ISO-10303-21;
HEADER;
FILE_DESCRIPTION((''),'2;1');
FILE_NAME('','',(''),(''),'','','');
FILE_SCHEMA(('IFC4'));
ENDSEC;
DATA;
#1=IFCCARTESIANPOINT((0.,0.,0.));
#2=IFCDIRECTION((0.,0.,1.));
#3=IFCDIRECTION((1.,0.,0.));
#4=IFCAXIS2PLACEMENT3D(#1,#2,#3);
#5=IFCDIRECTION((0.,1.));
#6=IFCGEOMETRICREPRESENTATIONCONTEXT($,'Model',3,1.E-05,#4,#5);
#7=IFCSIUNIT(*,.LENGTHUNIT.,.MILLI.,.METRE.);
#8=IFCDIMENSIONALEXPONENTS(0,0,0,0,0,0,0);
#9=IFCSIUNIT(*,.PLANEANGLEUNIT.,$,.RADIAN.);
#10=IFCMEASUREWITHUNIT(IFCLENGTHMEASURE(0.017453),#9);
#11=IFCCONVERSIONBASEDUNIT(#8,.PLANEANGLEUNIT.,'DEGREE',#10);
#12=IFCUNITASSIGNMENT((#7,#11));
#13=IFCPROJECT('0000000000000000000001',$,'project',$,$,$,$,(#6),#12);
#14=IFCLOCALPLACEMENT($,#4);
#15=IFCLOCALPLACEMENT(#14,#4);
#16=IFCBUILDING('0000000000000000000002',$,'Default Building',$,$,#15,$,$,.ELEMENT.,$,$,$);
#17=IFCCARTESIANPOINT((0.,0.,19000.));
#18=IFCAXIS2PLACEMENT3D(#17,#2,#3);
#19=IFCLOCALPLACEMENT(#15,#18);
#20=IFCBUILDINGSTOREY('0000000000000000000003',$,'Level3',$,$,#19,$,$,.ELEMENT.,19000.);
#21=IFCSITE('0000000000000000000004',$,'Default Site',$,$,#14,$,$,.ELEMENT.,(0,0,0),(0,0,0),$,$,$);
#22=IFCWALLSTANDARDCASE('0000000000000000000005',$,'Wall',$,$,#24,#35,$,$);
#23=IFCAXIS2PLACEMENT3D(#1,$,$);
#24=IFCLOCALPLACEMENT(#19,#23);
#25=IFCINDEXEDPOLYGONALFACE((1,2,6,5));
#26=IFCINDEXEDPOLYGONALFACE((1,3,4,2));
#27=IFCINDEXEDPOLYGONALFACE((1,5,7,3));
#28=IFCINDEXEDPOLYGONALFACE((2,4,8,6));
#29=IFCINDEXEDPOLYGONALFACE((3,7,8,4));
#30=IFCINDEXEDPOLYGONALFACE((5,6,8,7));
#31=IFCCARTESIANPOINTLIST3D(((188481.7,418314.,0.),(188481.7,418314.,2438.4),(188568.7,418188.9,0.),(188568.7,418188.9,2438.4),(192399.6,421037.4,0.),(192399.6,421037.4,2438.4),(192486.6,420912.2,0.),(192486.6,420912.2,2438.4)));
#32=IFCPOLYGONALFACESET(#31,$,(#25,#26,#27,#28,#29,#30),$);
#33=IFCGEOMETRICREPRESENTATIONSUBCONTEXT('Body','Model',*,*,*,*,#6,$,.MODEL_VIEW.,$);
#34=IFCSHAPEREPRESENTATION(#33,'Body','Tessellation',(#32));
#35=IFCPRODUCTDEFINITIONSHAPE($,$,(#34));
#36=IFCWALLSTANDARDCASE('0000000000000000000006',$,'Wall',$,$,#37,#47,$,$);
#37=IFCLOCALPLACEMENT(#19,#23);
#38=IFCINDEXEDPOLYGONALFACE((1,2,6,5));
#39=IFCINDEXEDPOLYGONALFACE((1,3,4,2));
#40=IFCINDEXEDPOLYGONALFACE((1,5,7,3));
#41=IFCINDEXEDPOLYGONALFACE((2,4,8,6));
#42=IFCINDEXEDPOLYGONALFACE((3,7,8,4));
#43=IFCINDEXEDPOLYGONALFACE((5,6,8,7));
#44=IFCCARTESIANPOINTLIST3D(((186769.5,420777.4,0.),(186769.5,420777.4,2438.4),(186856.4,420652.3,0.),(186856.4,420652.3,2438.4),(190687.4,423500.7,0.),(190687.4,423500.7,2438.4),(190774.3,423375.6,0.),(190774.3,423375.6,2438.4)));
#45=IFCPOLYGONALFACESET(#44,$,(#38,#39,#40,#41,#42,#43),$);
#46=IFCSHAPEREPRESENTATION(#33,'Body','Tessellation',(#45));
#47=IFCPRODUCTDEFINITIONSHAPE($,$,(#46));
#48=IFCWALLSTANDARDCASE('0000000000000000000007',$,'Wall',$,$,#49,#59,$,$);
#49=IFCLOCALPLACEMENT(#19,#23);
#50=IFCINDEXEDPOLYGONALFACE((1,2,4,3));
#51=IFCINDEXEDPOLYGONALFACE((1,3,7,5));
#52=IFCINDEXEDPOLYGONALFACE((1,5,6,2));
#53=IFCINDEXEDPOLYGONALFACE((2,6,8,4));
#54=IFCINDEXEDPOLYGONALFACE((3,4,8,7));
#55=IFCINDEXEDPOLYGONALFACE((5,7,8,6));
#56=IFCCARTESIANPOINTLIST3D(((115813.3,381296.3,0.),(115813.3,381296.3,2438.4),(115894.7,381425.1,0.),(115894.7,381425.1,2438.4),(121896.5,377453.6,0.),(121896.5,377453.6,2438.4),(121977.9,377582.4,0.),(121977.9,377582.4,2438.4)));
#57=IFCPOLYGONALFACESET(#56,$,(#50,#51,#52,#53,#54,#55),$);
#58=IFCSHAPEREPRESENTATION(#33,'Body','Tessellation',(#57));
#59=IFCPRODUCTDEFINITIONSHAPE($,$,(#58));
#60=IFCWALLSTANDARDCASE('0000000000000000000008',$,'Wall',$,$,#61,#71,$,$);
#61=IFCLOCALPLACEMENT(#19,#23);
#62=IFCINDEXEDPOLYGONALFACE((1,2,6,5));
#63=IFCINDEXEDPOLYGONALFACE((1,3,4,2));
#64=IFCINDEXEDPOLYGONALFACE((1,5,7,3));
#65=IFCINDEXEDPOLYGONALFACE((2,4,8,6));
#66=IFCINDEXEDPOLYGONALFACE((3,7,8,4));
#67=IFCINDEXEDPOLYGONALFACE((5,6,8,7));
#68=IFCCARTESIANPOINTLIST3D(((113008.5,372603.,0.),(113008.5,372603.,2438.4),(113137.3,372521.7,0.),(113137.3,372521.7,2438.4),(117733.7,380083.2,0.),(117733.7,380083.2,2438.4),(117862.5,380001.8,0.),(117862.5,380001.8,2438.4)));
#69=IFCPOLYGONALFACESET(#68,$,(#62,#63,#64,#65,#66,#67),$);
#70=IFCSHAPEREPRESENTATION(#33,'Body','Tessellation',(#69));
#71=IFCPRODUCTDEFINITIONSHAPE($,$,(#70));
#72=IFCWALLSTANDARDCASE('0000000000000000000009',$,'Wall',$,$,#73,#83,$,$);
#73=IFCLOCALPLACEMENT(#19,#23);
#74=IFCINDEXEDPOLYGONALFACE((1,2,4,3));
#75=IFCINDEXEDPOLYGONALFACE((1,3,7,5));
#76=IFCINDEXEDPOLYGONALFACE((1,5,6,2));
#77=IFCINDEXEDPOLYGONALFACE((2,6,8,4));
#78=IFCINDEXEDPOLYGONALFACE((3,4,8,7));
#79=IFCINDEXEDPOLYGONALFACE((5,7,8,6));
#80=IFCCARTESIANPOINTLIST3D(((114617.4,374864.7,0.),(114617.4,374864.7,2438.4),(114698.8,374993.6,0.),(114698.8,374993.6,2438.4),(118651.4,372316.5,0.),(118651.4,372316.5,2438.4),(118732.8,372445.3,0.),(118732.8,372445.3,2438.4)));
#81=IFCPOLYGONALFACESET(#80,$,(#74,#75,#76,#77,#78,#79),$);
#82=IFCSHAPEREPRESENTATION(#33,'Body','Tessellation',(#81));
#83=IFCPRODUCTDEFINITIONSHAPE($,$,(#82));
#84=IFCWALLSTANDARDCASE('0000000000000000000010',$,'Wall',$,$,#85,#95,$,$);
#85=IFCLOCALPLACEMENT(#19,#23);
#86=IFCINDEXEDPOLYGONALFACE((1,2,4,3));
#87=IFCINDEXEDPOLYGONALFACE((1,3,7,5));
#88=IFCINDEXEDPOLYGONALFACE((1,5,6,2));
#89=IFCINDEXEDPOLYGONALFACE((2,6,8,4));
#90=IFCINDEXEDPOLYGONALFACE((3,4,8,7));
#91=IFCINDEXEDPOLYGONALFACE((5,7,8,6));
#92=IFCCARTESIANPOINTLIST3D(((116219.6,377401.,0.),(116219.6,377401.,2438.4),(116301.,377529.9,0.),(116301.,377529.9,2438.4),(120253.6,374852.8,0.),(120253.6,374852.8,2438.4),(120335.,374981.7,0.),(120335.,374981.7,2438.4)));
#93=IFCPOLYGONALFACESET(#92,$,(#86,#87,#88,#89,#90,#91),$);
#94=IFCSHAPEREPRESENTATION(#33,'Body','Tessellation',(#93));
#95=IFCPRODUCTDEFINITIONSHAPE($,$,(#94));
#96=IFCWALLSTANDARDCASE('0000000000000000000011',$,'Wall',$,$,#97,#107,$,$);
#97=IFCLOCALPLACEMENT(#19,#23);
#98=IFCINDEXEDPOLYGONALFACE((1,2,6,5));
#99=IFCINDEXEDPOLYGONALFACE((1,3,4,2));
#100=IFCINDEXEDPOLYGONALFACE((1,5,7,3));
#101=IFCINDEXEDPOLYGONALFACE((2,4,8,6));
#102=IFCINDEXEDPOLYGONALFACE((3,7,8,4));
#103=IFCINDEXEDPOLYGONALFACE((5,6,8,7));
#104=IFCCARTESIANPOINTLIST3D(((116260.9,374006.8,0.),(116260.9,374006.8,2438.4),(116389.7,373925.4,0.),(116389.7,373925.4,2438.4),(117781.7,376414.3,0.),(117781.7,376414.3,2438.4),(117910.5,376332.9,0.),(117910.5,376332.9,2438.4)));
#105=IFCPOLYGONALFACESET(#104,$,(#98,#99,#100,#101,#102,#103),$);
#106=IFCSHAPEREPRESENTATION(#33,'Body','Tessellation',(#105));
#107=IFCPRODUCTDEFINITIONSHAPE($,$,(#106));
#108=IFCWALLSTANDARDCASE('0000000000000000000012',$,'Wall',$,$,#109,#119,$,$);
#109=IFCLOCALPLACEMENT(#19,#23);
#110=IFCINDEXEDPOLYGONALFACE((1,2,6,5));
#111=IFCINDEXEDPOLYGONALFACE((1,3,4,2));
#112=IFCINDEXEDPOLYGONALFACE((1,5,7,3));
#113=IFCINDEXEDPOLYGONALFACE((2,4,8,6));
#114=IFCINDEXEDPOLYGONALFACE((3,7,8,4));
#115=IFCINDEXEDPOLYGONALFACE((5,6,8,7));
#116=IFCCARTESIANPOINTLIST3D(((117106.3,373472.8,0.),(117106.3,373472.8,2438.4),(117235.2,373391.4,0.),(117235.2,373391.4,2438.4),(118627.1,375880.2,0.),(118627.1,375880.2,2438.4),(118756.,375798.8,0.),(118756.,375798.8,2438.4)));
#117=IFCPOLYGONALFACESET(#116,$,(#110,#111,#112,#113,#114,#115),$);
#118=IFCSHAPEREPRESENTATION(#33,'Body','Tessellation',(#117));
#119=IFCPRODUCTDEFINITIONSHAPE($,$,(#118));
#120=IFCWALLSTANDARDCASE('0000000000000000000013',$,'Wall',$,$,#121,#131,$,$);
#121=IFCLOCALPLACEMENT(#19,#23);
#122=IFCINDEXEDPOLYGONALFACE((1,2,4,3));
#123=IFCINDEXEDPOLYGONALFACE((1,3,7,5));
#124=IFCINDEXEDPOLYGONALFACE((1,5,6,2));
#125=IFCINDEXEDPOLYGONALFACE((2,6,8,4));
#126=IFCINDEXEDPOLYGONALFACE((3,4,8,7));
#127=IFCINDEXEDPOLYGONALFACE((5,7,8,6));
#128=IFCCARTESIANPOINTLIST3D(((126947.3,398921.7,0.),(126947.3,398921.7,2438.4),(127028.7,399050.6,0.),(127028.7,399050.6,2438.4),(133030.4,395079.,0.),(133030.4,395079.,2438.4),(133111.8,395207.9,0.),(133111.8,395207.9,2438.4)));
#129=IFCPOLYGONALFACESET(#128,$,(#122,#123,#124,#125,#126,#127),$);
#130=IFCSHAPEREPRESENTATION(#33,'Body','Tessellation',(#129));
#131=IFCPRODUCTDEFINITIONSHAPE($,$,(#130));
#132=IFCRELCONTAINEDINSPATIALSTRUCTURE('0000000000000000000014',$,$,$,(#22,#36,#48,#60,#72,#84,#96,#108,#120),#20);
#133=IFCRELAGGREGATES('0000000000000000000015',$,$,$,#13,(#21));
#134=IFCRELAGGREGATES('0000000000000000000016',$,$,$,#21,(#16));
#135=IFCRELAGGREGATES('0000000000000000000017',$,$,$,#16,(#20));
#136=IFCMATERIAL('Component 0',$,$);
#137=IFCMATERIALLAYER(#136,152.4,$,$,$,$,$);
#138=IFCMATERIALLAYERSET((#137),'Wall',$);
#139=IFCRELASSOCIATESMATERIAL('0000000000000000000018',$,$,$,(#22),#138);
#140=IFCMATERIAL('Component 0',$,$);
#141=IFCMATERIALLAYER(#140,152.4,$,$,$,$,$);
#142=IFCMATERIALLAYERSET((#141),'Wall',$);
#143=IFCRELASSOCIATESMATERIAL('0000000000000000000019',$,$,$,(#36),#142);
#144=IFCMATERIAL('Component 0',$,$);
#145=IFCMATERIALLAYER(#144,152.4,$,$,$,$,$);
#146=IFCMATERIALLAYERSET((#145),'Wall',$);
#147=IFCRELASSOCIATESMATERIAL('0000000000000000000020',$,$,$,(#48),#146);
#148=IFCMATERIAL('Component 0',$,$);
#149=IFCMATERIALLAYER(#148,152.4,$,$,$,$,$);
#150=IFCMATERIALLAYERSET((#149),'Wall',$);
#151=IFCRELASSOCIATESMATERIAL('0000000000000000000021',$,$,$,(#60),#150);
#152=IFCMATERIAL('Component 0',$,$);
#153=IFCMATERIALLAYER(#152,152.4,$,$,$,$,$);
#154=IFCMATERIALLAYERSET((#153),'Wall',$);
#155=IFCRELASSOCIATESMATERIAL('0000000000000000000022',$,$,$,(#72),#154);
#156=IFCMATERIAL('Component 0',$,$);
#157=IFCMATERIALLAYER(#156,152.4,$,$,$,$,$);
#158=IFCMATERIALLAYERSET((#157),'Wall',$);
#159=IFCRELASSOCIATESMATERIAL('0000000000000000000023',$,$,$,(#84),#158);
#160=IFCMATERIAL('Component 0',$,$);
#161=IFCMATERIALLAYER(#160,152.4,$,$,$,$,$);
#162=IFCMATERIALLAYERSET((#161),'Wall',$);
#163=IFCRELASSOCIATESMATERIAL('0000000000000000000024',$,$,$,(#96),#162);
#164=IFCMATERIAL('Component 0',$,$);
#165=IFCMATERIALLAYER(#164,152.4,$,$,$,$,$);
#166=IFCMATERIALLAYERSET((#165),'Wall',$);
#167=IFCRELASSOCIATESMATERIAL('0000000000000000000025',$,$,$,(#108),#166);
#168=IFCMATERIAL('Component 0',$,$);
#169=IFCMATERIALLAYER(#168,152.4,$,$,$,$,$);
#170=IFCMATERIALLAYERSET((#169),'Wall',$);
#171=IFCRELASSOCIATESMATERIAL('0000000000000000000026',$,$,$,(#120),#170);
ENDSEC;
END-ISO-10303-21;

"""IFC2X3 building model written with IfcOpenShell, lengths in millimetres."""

from ifc_helpers import new_model, entity, si_unit, converted_unit, direction, frame, origin_with_axes, place, context, subcontext, project, spatial, polyline, outline, extrude, material, layer, layer_set, layer_usage, element, save


model = new_model("IFC2X3")

# Units and contexts
model_context = context("Model", 3, precision=1e-05, world=origin_with_axes(), true_north=direction((0.0, 1.0)))
body_context = subcontext(model_context, "Body", "Model", "MODEL_VIEW")
ifc_project = project(units=[si_unit("LENGTHUNIT", "METRE", prefix="MILLI"), converted_unit("PLANEANGLEUNIT", "DEGREE", entity("IfcLengthMeasure", 0.017453), si_unit("PLANEANGLEUNIT", "RADIAN"), dimensions=[0, 0, 0, 0, 0, 0, 0])], contexts=[model_context])

# Site, building, storey
site_placement = place(None, origin_with_axes())
site = spatial("IfcSite", under=ifc_project, at=site_placement, Name="Default Site", CompositionType="ELEMENT", RefLatitude=(0, 0, 0), RefLongitude=(0, 0, 0))
building_placement = place(site_placement, origin_with_axes())
building = spatial("IfcBuilding", under=site, at=building_placement, Name="Default Building", CompositionType="ELEMENT")
storey_placement = place(building_placement, frame((0.0, 0.0, 19000.0), z_axis=(0.0, 0.0, 1.0), x_axis=(1.0, 0.0, 0.0)))
storey = spatial("IfcBuildingStorey", under=building, at=storey_placement, Name="Level3", CompositionType="ELEMENT", Elevation=19000.0)

# Walls
ifc_material_1 = material(Name="Component 0")
ifc_layer_1 = layer(ifc_material_1, 152.4)
ifc_layer_set_1 = layer_set([ifc_layer_1], Name="Wall")
ifc_layer_usage_1 = layer_usage(ifc_layer_set_1, "AXIS2", "POSITIVE", -76.2)
wall_1_placement = place(storey_placement, frame((188462.7, 418208.0, 0.0), z_axis=(0.0, 0.0, 1.0), x_axis=(0.82112, 0.570755, 0.0)))
element("IfcWallStandardCase", 1, at=wall_1_placement, inside=storey, material=ifc_layer_usage_1, Name="Wall", context=body_context, shape_type="SweptSolid", body=[
    extrude(outline(polyline([(76.2, -76.2), (76.2, 76.2), (4847.6, 76.2), (4847.6, -76.2), (76.2, -76.2)])), origin_with_axes(), (0.0, 0.0, 1.0), 2438.4),
])
ifc_material_2 = material(Name="Component 0")
ifc_layer_2 = layer(ifc_material_2, 152.4)
ifc_layer_set_2 = layer_set([ifc_layer_2], Name="Wall")
ifc_layer_usage_2 = layer_usage(ifc_layer_set_2, "AXIS2", "POSITIVE", -76.2)
wall_2_placement = place(storey_placement, frame((186750.4, 420671.3, 0.0), z_axis=(0.0, 0.0, 1.0), x_axis=(0.82112, 0.570755, 0.0)))
element("IfcWallStandardCase", 2, at=wall_2_placement, inside=storey, material=ifc_layer_usage_2, Name="Wall", context=body_context, shape_type="SweptSolid", body=[
    extrude(outline(polyline([(76.2, -76.2), (76.2, 76.2), (4847.6, 76.2), (4847.6, -76.2), (76.2, -76.2)])), origin_with_axes(), (0.0, 0.0, 1.0), 2438.4),
])
ifc_material_3 = material(Name="Component 0")
ifc_layer_3 = layer(ifc_material_3, 152.4)
ifc_layer_set_3 = layer_set([ifc_layer_3], Name="Wall")
ifc_layer_usage_3 = layer_usage(ifc_layer_set_3, "AXIS2", "POSITIVE", -76.2)
wall_3_placement = place(storey_placement, frame((122001.6, 377477.3, 0.0), z_axis=(0.0, 0.0, 1.0), x_axis=(-0.845443, 0.534065, 0.0)))
element("IfcWallStandardCase", 3, at=wall_3_placement, inside=storey, material=ifc_layer_usage_3, Name="Wall", context=body_context, shape_type="SweptSolid", body=[
    extrude(outline(polyline([(76.2, -76.2), (76.2, 76.2), (7271.4, 76.2), (7271.4, -76.2), (76.2, -76.2)])), origin_with_axes(), (0.0, 0.0, 1.0), 2438.4),
])
ifc_material_4 = material(Name="Component 0")
ifc_layer_4 = layer(ifc_material_4, 152.4)
ifc_layer_set_4 = layer_set([ifc_layer_4], Name="Wall")
ifc_layer_usage_4 = layer_usage(ifc_layer_set_4, "AXIS2", "POSITIVE", -76.2)
wall_4_placement = place(storey_placement, frame((113032.2, 372497.9, 0.0), z_axis=(0.0, 0.0, 1.0), x_axis=(0.534065, 0.845443, 0.0)))
element("IfcWallStandardCase", 4, at=wall_4_placement, inside=storey, material=ifc_layer_usage_4, Name="Wall", context=body_context, shape_type="SweptSolid", body=[
    extrude(outline(polyline([(76.2, -76.2), (76.2, 76.2), (8923.8, 76.2), (8923.8, -76.2), (76.2, -76.2)])), origin_with_axes(), (0.0, 0.0, 1.0), 2438.4),
])
ifc_material_5 = material(Name="Component 0")
ifc_layer_5 = layer(ifc_material_5, 152.4)
ifc_layer_set_5 = layer_set([ifc_layer_5], Name="Wall")
ifc_layer_usage_5 = layer_usage(ifc_layer_set_5, "AXIS2", "POSITIVE", -76.2)
wall_5_placement = place(storey_placement, frame((114593.7, 374969.8, 0.0), z_axis=(0.0, 0.0, 1.0), x_axis=(0.845443, -0.534065, 0.0)))
element("IfcWallStandardCase", 5, at=wall_5_placement, inside=storey, material=ifc_layer_usage_5, Name="Wall", context=body_context, shape_type="SweptSolid", body=[
    extrude(outline(polyline([(76.2, -76.2), (76.2, 76.2), (4847.6, 76.2), (4847.6, -76.2), (76.2, -76.2)])), origin_with_axes(), (0.0, 0.0, 1.0), 2438.4),
])
ifc_material_6 = material(Name="Component 0")
ifc_layer_6 = layer(ifc_material_6, 152.4)
ifc_layer_set_6 = layer_set([ifc_layer_6], Name="Wall")
ifc_layer_usage_6 = layer_usage(ifc_layer_set_6, "AXIS2", "POSITIVE", -76.2)
wall_6_placement = place(storey_placement, frame((116195.9, 377506.2, 0.0), z_axis=(0.0, 0.0, 1.0), x_axis=(0.845443, -0.534065, 0.0)))
element("IfcWallStandardCase", 6, at=wall_6_placement, inside=storey, material=ifc_layer_usage_6, Name="Wall", context=body_context, shape_type="SweptSolid", body=[
    extrude(outline(polyline([(76.2, -76.2), (76.2, 76.2), (4847.6, 76.2), (4847.6, -76.2), (76.2, -76.2)])), origin_with_axes(), (0.0, 0.0, 1.0), 2438.4),
])
ifc_material_7 = material(Name="Component 0")
ifc_layer_7 = layer(ifc_material_7, 152.4)
ifc_layer_set_7 = layer_set([ifc_layer_7], Name="Wall")
ifc_layer_usage_7 = layer_usage(ifc_layer_set_7, "AXIS2", "POSITIVE", -76.2)
wall_7_placement = place(storey_placement, frame((116284.6, 373901.7, 0.0), z_axis=(0.0, 0.0, 1.0), x_axis=(0.534065, 0.845443, 0.0)))
element("IfcWallStandardCase", 7, at=wall_7_placement, inside=storey, material=ifc_layer_usage_7, Name="Wall", context=body_context, shape_type="SweptSolid", body=[
    extrude(outline(polyline([(76.2, -76.2), (76.2, 76.2), (2923.8, 76.2), (2923.8, -76.2), (76.2, -76.2)])), origin_with_axes(), (0.0, 0.0, 1.0), 2438.4),
])
ifc_material_8 = material(Name="Component 0")
ifc_layer_8 = layer(ifc_material_8, 152.4)
ifc_layer_set_8 = layer_set([ifc_layer_8], Name="Wall")
ifc_layer_usage_8 = layer_usage(ifc_layer_set_8, "AXIS2", "POSITIVE", -76.2)
wall_8_placement = place(storey_placement, frame((117130.0, 373367.6, 0.0), z_axis=(0.0, 0.0, 1.0), x_axis=(0.534065, 0.845443, 0.0)))
element("IfcWallStandardCase", 8, at=wall_8_placement, inside=storey, material=ifc_layer_usage_8, Name="Wall", context=body_context, shape_type="SweptSolid", body=[
    extrude(outline(polyline([(76.2, -76.2), (76.2, 76.2), (2923.8, 76.2), (2923.8, -76.2), (76.2, -76.2)])), origin_with_axes(), (0.0, 0.0, 1.0), 2438.4),
])
ifc_material_9 = material(Name="Component 0")
ifc_layer_9 = layer(ifc_material_9, 152.4)
ifc_layer_set_9 = layer_set([ifc_layer_9], Name="Wall")
ifc_layer_usage_9 = layer_usage(ifc_layer_set_9, "AXIS2", "POSITIVE", -76.2)
wall_9_placement = place(storey_placement, frame((126923.6, 399026.8, 0.0), z_axis=(0.0, 0.0, 1.0), x_axis=(0.845443, -0.534065, 0.0)))
element("IfcWallStandardCase", 9, at=wall_9_placement, inside=storey, material=ifc_layer_usage_9, Name="Wall", context=body_context, shape_type="SweptSolid", body=[
    extrude(outline(polyline([(76.2, -76.2), (76.2, 76.2), (7271.4, 76.2), (7271.4, -76.2), (76.2, -76.2)])), origin_with_axes(), (0.0, 0.0, 1.0), 2438.4),
])

save(model, "model.ifc")
